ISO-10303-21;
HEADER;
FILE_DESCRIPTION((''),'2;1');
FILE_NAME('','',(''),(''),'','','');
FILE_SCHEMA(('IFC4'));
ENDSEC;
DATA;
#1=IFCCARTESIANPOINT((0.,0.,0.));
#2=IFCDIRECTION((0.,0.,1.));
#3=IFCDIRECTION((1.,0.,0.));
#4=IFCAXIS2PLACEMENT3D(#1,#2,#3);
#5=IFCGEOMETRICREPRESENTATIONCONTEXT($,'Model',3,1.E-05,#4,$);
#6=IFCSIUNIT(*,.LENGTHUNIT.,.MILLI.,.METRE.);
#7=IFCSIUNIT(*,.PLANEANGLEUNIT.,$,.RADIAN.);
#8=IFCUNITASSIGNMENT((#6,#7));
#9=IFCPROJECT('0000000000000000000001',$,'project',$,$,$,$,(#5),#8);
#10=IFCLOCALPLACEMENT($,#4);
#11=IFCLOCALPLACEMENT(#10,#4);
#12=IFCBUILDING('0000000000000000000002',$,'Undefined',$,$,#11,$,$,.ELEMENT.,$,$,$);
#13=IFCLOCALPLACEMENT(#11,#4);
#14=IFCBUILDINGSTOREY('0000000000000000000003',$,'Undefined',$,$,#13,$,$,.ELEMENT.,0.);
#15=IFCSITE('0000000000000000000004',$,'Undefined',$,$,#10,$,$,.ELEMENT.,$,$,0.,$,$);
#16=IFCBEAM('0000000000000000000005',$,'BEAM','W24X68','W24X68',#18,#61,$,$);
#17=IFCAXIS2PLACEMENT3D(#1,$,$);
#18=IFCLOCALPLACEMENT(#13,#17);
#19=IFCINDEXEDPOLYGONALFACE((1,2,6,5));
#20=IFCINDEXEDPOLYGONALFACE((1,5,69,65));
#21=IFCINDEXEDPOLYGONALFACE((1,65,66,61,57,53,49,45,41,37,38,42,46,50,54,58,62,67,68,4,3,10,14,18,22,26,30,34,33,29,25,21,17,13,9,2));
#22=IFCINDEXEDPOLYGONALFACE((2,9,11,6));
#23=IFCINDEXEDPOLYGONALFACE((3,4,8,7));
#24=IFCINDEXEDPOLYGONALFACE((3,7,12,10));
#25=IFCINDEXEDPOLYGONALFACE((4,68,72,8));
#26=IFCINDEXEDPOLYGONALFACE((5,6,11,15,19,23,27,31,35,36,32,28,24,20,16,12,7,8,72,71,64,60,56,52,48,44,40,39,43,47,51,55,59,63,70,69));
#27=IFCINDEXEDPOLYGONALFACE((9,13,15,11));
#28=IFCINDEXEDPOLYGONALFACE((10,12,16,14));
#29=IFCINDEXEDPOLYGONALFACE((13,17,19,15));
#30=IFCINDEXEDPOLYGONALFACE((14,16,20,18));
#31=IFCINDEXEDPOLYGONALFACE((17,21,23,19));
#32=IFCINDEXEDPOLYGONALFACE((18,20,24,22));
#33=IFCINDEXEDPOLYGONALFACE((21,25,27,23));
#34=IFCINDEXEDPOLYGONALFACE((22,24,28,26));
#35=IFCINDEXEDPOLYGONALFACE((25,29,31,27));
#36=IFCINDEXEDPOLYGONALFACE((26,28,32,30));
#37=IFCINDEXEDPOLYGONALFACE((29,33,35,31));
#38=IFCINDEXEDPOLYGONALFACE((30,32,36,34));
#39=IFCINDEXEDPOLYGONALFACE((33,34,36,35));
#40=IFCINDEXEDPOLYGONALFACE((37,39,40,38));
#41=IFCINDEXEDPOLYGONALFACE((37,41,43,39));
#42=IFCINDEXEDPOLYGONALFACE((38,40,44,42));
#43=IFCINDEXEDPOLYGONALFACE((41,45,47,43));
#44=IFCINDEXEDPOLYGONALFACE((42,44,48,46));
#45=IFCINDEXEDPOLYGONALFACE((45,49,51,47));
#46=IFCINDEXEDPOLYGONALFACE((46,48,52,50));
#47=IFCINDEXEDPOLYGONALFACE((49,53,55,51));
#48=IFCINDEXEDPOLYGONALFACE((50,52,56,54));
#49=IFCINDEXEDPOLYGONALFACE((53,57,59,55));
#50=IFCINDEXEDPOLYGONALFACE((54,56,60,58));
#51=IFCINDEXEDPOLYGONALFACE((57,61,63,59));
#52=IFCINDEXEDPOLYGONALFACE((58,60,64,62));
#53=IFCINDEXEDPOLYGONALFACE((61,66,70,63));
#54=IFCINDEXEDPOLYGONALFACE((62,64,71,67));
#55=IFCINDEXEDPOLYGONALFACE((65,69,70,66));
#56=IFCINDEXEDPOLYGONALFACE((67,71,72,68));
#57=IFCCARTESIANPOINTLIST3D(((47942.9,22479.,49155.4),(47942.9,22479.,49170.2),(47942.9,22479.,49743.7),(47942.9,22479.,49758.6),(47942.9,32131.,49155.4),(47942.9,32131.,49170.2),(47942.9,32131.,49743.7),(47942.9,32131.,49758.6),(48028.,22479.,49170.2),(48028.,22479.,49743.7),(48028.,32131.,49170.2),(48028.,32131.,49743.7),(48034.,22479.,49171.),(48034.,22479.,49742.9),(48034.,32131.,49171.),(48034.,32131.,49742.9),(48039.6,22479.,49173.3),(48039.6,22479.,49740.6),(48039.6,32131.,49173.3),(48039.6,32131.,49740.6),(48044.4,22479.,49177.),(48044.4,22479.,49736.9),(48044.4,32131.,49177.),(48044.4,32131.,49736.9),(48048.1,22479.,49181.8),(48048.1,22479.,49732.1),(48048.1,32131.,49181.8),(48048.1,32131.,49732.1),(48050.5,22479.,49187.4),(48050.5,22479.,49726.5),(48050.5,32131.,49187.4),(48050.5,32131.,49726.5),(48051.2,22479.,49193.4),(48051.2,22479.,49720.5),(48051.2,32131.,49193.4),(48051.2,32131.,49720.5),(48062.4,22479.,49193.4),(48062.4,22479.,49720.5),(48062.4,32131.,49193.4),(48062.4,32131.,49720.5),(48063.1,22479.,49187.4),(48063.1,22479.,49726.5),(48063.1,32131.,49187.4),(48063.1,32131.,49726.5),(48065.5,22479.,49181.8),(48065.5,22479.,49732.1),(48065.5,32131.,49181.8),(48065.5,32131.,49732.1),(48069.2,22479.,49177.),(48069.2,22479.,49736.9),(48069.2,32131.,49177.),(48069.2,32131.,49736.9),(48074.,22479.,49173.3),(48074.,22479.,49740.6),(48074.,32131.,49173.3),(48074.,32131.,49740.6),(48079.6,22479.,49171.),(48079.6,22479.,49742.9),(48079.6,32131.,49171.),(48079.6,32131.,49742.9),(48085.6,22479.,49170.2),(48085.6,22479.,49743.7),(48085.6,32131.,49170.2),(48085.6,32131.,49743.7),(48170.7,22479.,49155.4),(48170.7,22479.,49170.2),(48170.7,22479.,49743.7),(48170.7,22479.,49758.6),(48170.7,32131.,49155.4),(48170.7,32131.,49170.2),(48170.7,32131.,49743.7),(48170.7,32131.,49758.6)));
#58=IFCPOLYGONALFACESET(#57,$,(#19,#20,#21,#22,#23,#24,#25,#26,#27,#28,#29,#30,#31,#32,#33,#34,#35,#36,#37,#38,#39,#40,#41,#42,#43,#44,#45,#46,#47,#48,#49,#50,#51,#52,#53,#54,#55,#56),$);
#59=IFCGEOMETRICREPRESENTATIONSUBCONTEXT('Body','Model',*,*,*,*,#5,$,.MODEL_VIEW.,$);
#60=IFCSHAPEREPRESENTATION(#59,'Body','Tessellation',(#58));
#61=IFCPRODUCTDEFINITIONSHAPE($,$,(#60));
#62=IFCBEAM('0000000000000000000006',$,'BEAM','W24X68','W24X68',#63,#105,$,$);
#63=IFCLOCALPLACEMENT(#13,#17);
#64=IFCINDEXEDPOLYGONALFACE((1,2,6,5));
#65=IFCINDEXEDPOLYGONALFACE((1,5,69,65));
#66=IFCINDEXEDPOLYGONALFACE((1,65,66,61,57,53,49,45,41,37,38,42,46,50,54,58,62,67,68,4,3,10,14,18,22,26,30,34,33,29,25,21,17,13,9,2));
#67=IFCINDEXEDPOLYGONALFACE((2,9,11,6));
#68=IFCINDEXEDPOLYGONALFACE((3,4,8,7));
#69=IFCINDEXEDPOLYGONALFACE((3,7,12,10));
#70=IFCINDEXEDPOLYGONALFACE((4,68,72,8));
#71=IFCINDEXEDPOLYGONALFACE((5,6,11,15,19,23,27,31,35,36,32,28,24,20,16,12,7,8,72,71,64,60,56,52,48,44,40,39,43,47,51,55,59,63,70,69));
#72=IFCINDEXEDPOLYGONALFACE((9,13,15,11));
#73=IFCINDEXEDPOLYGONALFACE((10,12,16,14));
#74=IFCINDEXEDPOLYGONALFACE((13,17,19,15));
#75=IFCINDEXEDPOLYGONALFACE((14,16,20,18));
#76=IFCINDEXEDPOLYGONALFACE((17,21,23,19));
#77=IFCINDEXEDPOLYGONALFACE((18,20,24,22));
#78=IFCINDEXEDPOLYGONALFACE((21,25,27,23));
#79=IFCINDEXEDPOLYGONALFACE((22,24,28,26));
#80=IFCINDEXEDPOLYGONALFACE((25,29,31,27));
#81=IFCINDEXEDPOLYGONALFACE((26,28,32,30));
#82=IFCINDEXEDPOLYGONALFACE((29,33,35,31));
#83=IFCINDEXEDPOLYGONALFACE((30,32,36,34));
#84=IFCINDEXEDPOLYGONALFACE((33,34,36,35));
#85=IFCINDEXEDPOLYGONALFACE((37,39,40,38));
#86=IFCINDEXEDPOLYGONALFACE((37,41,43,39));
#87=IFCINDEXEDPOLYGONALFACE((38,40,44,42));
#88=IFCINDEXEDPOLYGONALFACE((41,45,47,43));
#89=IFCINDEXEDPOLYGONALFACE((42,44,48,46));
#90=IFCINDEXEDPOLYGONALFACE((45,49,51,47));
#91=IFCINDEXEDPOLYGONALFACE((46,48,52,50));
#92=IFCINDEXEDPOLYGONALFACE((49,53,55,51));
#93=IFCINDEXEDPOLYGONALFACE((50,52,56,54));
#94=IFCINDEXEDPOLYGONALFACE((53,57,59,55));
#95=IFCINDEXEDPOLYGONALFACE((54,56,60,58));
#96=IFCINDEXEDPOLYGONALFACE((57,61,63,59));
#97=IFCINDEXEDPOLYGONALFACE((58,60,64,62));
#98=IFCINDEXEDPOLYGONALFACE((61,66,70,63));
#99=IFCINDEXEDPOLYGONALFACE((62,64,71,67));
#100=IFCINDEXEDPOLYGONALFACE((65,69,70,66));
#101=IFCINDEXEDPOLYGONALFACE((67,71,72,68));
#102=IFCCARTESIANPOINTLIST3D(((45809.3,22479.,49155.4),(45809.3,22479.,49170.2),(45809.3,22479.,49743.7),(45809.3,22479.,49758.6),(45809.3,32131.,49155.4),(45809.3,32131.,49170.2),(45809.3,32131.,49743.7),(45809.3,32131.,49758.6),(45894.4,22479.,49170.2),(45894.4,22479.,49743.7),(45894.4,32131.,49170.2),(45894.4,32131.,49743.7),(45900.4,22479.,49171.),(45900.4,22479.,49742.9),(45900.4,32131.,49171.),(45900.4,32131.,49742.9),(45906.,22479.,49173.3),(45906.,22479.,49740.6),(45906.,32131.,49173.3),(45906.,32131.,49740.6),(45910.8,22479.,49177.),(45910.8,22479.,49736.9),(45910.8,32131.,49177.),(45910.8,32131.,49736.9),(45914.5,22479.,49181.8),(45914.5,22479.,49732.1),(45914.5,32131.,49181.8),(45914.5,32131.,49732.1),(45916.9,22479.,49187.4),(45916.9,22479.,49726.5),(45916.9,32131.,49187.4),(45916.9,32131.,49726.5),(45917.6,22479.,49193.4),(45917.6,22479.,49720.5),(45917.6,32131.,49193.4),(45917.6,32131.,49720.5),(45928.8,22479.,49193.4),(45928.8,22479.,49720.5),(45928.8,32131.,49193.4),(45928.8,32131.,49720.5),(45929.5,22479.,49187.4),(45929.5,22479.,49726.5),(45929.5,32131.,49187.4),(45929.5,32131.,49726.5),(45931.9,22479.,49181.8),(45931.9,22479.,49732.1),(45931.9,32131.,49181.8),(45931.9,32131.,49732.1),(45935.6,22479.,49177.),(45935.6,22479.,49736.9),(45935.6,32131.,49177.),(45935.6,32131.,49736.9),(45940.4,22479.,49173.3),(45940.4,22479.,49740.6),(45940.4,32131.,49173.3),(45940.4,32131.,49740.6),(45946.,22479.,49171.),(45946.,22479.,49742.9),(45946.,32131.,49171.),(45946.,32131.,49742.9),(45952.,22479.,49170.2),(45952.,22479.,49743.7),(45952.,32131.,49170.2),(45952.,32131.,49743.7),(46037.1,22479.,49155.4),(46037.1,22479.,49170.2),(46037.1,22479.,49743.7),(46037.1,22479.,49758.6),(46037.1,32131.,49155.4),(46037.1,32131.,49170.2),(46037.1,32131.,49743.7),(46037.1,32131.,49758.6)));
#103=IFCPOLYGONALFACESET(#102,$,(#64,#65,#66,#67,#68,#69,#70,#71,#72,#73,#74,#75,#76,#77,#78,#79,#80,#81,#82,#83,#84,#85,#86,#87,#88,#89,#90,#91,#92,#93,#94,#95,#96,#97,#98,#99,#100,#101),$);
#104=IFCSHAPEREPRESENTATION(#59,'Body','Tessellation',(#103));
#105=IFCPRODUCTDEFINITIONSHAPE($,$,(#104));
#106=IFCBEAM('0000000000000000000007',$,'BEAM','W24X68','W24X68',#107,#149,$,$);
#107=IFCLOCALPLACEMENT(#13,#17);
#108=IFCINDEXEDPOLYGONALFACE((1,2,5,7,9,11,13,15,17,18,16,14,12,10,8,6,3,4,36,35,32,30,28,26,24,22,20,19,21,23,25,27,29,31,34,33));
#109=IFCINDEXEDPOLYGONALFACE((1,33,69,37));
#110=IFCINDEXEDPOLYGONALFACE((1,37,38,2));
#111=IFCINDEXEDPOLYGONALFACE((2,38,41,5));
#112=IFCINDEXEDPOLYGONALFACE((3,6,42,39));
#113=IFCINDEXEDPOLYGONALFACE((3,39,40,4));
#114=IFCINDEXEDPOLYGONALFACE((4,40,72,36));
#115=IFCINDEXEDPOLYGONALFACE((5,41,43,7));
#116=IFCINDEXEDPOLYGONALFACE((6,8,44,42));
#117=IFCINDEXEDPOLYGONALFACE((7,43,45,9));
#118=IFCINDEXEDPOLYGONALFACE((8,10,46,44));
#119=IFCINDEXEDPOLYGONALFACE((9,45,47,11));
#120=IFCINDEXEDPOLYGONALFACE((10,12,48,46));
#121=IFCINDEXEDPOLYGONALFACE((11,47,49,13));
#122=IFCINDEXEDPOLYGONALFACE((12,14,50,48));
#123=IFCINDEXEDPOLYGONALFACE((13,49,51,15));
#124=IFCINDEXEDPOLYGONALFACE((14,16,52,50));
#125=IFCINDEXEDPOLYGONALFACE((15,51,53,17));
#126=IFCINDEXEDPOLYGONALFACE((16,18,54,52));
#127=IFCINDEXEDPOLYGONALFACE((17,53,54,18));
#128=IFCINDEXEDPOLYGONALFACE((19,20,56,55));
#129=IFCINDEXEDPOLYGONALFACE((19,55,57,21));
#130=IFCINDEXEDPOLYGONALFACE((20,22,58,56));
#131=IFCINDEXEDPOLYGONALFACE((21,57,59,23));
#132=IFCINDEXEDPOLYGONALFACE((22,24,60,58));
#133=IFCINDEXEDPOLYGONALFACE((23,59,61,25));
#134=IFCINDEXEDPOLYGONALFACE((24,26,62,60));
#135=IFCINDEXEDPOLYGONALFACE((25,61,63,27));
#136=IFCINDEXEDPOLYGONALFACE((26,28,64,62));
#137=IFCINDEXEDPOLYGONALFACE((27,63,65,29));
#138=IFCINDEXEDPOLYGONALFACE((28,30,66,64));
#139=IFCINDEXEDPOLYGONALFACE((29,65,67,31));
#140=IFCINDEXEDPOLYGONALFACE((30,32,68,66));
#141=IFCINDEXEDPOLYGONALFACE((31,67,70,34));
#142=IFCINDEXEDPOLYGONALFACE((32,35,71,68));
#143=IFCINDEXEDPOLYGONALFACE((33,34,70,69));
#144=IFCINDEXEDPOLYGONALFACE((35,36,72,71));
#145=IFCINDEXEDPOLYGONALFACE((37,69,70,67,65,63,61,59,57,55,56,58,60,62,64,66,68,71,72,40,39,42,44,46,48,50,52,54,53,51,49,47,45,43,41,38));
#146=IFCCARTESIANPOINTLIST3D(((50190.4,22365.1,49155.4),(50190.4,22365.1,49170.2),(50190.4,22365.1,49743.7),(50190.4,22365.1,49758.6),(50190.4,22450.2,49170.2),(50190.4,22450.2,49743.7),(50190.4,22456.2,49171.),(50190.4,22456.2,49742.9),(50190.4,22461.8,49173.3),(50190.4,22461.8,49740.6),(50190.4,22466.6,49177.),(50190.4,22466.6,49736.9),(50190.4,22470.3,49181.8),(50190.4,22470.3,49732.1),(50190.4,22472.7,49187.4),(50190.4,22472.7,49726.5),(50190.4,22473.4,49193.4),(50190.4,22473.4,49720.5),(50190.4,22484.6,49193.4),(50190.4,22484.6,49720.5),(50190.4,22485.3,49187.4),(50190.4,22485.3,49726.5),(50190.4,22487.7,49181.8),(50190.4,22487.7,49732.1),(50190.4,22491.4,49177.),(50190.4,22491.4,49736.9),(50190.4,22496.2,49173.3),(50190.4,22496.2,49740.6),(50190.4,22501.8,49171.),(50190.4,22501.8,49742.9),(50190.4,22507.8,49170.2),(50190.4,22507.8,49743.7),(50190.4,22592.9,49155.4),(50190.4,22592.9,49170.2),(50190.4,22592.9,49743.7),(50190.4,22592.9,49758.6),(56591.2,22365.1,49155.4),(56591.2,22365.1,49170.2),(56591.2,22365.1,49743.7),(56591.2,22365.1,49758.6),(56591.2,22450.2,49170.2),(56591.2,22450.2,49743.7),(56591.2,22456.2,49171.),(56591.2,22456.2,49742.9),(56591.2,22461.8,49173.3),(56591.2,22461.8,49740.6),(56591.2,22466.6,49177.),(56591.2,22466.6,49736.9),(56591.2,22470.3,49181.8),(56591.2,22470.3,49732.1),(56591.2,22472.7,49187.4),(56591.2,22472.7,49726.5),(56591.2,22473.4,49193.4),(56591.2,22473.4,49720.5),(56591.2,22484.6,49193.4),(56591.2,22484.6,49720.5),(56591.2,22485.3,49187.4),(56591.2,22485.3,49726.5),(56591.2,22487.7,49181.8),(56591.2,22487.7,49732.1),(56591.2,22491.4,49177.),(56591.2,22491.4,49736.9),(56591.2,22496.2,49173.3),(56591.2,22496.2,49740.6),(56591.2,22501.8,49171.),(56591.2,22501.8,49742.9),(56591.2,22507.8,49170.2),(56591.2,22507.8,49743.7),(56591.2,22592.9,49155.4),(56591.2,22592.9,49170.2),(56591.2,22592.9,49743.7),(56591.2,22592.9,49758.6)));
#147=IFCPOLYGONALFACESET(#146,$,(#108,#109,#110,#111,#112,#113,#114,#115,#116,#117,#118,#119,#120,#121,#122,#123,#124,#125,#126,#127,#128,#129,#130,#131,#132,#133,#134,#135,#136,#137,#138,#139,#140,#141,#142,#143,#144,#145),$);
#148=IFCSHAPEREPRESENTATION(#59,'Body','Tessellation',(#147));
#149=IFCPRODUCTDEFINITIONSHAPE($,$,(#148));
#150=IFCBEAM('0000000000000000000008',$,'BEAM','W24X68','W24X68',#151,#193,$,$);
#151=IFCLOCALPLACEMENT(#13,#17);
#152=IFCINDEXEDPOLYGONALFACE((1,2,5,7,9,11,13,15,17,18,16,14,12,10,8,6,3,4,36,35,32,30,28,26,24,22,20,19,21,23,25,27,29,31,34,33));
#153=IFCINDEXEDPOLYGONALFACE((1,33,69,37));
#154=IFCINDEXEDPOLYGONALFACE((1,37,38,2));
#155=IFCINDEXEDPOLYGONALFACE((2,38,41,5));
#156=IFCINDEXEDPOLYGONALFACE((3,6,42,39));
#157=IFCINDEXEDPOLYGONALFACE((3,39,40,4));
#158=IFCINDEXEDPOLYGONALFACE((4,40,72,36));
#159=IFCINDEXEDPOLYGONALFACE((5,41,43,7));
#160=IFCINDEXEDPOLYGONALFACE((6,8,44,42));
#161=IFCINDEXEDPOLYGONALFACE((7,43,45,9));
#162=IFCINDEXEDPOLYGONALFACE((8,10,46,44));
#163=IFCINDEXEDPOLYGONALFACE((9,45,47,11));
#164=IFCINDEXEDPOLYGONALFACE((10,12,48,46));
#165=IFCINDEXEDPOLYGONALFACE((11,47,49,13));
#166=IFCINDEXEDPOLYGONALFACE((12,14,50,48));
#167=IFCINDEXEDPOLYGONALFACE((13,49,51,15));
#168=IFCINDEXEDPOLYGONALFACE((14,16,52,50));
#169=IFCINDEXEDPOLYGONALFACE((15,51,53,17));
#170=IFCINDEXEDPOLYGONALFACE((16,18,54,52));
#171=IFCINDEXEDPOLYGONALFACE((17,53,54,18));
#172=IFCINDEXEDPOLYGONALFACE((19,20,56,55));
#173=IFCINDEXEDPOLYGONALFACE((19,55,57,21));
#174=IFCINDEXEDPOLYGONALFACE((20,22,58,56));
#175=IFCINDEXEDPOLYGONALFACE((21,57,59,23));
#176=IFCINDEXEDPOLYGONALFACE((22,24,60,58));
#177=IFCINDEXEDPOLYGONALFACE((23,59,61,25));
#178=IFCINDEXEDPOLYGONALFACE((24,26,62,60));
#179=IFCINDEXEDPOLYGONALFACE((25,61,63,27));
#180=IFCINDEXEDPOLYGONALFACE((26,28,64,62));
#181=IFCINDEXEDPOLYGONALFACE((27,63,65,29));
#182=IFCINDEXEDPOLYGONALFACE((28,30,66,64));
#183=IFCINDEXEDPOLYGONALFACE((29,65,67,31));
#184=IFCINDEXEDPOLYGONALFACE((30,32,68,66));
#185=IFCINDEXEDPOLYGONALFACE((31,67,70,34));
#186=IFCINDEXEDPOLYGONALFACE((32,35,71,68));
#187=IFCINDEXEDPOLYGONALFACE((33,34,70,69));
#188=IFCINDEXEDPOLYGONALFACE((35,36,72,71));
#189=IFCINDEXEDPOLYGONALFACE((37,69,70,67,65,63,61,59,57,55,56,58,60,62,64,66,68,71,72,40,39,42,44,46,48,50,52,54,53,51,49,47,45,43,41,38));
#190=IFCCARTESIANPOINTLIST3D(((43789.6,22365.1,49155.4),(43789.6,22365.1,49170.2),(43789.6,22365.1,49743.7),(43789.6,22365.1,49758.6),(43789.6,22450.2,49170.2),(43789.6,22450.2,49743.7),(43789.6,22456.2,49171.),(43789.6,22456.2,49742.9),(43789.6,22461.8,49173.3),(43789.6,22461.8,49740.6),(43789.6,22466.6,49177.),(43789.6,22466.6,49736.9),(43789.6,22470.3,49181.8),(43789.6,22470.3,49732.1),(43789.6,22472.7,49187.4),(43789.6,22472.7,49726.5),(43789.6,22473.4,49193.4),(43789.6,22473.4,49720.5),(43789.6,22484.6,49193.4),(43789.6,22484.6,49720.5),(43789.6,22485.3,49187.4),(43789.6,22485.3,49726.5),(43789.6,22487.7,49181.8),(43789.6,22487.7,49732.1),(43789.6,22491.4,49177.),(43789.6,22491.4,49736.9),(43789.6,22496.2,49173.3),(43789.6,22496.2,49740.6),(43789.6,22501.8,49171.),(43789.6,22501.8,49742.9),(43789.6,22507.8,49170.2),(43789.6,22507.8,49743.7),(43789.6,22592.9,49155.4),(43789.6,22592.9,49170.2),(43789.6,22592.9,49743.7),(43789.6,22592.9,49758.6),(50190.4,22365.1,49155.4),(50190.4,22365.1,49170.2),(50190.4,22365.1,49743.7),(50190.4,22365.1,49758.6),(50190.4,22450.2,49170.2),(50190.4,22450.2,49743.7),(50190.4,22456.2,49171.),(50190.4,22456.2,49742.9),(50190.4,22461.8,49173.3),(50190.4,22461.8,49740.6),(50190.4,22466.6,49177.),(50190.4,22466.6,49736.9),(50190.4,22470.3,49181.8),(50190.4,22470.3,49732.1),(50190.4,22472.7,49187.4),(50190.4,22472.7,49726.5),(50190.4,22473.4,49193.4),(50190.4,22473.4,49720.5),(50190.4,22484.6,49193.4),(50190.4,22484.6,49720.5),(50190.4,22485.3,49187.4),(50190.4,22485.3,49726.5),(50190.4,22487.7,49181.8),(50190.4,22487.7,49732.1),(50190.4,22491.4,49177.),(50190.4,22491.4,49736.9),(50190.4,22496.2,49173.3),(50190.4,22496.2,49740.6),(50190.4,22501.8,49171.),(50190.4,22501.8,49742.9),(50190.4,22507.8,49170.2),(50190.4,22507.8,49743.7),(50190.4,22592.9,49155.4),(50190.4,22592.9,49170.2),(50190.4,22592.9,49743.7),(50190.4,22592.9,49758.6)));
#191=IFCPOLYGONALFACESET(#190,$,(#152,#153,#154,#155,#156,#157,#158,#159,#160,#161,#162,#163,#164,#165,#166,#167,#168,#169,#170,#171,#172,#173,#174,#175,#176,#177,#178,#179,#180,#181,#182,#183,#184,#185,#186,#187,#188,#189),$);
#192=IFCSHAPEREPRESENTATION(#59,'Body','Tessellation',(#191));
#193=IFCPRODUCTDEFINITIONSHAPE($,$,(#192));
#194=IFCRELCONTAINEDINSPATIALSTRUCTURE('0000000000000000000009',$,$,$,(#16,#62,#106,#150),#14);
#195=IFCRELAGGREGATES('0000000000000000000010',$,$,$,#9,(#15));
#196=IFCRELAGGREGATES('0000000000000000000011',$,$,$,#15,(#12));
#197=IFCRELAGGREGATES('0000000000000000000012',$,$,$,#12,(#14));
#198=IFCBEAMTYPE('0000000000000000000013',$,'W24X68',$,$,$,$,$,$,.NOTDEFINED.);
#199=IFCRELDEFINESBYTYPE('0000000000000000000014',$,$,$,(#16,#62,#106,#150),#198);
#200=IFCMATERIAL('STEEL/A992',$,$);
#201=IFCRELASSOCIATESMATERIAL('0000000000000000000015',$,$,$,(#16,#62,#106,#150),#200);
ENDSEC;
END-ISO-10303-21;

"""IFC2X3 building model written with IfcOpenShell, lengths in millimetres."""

from ifc_helpers import new_model, si_unit, frame, origin_with_axes, origin_2d_with_axis, place, context, subcontext, project, spatial, i_section, extrude, material, type_object, element, save


model = new_model("IFC2X3")

# Units and contexts
model_context = context("Model", 3, precision=1e-05, world=origin_with_axes())
body_context = subcontext(model_context, "Body", "Model", "MODEL_VIEW")
ifc_project = project(units=[si_unit("LENGTHUNIT", "METRE", prefix="MILLI"), si_unit("PLANEANGLEUNIT", "RADIAN")], contexts=[model_context])

# Site, building, storey
site_placement = place(None, origin_with_axes())
site = spatial("IfcSite", under=ifc_project, at=site_placement, Name="Undefined", CompositionType="ELEMENT", RefElevation=0.0)
building_placement = place(site_placement, origin_with_axes())
building = spatial("IfcBuilding", under=site, at=building_placement, Name="Undefined", CompositionType="ELEMENT")
storey_placement = place(building_placement, origin_with_axes())
storey = spatial("IfcBuildingStorey", under=building, at=storey_placement, Name="Undefined", CompositionType="ELEMENT", Elevation=0.0)

# Shared definitions
ifc_material = material(Name="STEEL/A992")

# Beams
beam_type = type_object("IfcBeamType", Name="W24X68", PredefinedType="NOTDEFINED")
for number, where, z_axis, x_axis, name in (
    (1, (48056.8, 22479.0, 49457.0), (0.0, 0.0, 1.0), (0.0, 1.0, 0.0), "BEAM"),
    (2, (45923.2, 22479.0, 49457.0), (0.0, 0.0, 1.0), (0.0, 1.0, 0.0), "BEAM"),
):
    element("IfcBeam", number, at=place(storey_placement, frame(where, z_axis=z_axis, x_axis=x_axis)), inside=storey, type_object=beam_type, material=ifc_material, Name=name, Description="W24X68", ObjectType="W24X68", context=body_context, shape_type="SweptSolid", body=[
        extrude(i_section(OverallWidth=227.8, OverallDepth=603.2, WebThickness=11.1, FlangeThickness=14.9, FilletRadius=23.2, at=origin_2d_with_axis()), frame((9652.0, 0.0, 0.0), z_axis=(-1.0, 0.0, 0.0), x_axis=(0.0, -1.0, 0.0)), (0.0, 0.0, 1.0), 9652.0),
    ])
beam_1_placement = place(storey_placement, frame((50190.4, 22479.0, 49457.0), z_axis=(0.0, 0.0, 1.0), x_axis=(1.0, 0.0, 0.0)))
element("IfcBeam", 3, at=beam_1_placement, inside=storey, type_object=beam_type, material=ifc_material, Name="BEAM", Description="W24X68", ObjectType="W24X68", context=body_context, shape_type="SweptSolid", body=[
    extrude(i_section(OverallWidth=227.8, OverallDepth=603.2, WebThickness=11.1, FlangeThickness=14.9, FilletRadius=23.2, at=origin_2d_with_axis()), frame((6400.8, 0.0, 0.0), z_axis=(-1.0, 0.0, 0.0), x_axis=(0.0, -1.0, 0.0)), (0.0, 0.0, 1.0), 6400.8),
])
beam_2_placement = place(storey_placement, frame((43789.6, 22479.0, 49457.0), z_axis=(0.0, 0.0, 1.0), x_axis=(1.0, 0.0, 0.0)))
element("IfcBeam", 4, at=beam_2_placement, inside=storey, type_object=beam_type, material=ifc_material, Name="BEAM", Description="W24X68", ObjectType="W24X68", context=body_context, shape_type="SweptSolid", body=[
    extrude(i_section(OverallWidth=227.8, OverallDepth=603.2, WebThickness=11.1, FlangeThickness=14.9, FilletRadius=23.2, at=origin_2d_with_axis()), frame((6400.8, 0.0, 0.0), z_axis=(-1.0, 0.0, 0.0), x_axis=(0.0, -1.0, 0.0)), (0.0, 0.0, 1.0), 6400.8),
])

save(model, "model.ifc")
